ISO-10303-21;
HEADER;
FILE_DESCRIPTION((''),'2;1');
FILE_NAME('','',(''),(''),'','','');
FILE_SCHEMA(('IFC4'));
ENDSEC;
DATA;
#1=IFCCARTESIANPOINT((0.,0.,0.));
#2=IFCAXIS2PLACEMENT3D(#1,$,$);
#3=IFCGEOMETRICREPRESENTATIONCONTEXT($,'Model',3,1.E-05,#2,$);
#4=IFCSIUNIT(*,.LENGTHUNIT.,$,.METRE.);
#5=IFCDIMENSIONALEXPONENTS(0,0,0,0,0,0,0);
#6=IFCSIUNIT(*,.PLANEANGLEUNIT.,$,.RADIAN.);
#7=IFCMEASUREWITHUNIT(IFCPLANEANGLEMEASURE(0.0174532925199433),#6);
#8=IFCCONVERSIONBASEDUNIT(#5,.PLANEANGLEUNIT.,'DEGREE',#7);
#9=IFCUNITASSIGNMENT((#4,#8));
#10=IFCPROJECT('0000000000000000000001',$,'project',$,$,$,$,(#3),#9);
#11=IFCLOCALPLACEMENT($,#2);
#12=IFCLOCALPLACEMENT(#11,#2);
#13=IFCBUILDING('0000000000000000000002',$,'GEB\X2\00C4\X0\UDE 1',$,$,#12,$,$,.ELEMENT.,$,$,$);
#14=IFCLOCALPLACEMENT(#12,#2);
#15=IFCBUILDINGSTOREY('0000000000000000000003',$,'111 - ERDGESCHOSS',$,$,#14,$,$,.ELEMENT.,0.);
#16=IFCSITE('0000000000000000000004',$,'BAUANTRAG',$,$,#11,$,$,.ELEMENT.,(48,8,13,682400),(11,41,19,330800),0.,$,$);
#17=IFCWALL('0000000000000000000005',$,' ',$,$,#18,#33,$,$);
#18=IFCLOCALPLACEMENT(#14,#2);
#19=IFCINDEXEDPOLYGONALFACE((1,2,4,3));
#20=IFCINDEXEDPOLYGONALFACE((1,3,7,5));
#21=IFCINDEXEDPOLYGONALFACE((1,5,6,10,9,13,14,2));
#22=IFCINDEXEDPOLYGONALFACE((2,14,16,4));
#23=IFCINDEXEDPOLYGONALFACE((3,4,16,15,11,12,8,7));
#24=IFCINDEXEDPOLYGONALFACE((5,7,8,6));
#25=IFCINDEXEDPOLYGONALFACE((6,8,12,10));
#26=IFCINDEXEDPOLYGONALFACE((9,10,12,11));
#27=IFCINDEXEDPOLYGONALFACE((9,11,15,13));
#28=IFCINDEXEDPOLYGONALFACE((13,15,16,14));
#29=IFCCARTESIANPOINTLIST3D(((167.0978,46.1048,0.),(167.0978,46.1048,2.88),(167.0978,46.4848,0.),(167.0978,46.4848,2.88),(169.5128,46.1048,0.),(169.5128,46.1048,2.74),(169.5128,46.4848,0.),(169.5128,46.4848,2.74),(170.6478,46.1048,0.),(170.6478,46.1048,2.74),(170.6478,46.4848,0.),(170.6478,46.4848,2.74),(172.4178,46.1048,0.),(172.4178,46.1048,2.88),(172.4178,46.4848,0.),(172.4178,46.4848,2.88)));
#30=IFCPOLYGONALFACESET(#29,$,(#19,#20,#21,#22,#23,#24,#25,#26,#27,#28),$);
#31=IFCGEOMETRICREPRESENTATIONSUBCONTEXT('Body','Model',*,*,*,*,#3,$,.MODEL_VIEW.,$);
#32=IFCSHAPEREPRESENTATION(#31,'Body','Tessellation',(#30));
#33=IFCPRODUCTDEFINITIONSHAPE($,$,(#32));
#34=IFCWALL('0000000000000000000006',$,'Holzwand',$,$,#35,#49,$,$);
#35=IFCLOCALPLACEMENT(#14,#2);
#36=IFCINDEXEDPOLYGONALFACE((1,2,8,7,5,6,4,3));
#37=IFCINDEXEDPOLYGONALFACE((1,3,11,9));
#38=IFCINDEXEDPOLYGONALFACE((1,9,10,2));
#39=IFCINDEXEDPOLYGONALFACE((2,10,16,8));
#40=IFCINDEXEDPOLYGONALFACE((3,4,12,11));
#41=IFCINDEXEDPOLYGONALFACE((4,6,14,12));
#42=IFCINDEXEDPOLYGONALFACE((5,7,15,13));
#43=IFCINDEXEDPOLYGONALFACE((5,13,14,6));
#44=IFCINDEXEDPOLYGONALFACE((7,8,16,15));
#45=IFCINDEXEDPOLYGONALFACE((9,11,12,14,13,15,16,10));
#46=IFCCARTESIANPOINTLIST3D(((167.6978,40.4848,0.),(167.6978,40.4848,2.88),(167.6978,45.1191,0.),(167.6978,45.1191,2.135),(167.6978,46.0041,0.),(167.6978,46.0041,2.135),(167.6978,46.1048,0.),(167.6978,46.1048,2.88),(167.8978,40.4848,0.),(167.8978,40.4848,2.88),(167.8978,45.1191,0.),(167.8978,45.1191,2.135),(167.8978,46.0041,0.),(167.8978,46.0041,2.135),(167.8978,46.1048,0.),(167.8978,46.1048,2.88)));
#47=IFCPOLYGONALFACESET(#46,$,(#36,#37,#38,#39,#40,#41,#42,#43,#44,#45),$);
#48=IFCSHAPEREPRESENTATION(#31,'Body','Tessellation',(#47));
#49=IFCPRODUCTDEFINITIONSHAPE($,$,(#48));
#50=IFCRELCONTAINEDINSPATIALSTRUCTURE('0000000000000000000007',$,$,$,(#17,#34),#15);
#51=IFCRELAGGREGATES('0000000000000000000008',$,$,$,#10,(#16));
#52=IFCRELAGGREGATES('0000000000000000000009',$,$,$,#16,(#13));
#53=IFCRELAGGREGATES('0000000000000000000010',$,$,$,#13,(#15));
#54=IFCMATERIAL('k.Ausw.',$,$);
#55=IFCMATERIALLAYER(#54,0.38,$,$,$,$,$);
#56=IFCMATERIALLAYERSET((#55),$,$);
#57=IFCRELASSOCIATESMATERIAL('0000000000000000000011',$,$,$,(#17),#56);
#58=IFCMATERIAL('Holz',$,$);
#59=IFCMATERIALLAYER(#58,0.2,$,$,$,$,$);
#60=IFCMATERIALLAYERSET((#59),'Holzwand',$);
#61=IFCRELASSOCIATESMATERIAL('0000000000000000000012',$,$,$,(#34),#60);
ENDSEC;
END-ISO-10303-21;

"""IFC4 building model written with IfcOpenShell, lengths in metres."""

from ifc_helpers import new_model, entity, si_unit, converted_unit, frame, frame_2d, origin, origin_with_axes, place, context, subcontext, project, spatial, polyline, rectangle, outline, extrude, material, layer, layer_set, layer_usage, element, save


model = new_model("IFC4")

# Units and contexts
model_context = context("Model", 3, precision=1e-05, world=origin())
body_context = subcontext(model_context, "Body", "Model", "MODEL_VIEW")
ifc_project = project(units=[si_unit("LENGTHUNIT", "METRE"), converted_unit("PLANEANGLEUNIT", "DEGREE", entity("IfcPlaneAngleMeasure", 0.0174532925199433), si_unit("PLANEANGLEUNIT", "RADIAN"), dimensions=[0, 0, 0, 0, 0, 0, 0])], contexts=[model_context])

# Site, building, storey
site_placement = place(None, origin())
site = spatial("IfcSite", under=ifc_project, at=site_placement, Name="BAUANTRAG", CompositionType="ELEMENT", RefLatitude=(48, 8, 13, 682400), RefLongitude=(11, 41, 19, 330800), RefElevation=0.0)
building_placement = place(site_placement, origin())
building = spatial("IfcBuilding", under=site, at=building_placement, Name="GEBÄUDE 1", CompositionType="ELEMENT")
storey_placement = place(building_placement, origin())
storey = spatial("IfcBuildingStorey", under=building, at=storey_placement, Name="111 - ERDGESCHOSS", CompositionType="ELEMENT", Elevation=0.0)

# Walls, openings
ifc_material_1 = material(Name="k.Ausw.")
ifc_layer_1 = layer(ifc_material_1, 0.38)
ifc_layer_set_1 = layer_set([ifc_layer_1])
ifc_layer_usage_1 = layer_usage(ifc_layer_set_1, "AXIS2", "POSITIVE", 0.0)
wall_1_placement = place(storey_placement, frame((172.4178, 46.4848, 0.0), z_axis=(0.0, 0.0, 1.0), x_axis=(-1.0, 0.0, 0.0)))
wall_1 = element("IfcWall", 1, at=wall_1_placement, inside=storey, material=ifc_layer_usage_1, Name=" ", context=body_context, shape_type="SweptSolid", body=[
    extrude(rectangle(XDim=5.32, YDim=0.38, at=frame_2d((2.66, 0.19), x_axis=(1.0, 0.0))), origin_with_axes(), (0.0, 0.0, 1.0), 2.88),
])
opening_1_placement = place(wall_1_placement, frame((2.905, 0.38, 0.0), z_axis=(0.0, -1.0, 0.0), x_axis=(0.0, 0.0, 1.0)))
element("IfcOpeningElement", 2, at=opening_1_placement, cuts=wall_1, ObjectType="Opening", context=body_context, shape_type="SweptSolid", body=[
    extrude(outline(polyline([(0.0, 1.135), (2.74, 1.135), (2.74, 0.0), (0.0, 0.0), (0.0, 1.135)])), origin_with_axes(), (0.0, 0.0, 1.0), 0.38),
])
ifc_material_2 = material(Name="Holz")
ifc_layer_2 = layer(ifc_material_2, 0.2)
ifc_layer_set_2 = layer_set([ifc_layer_2], Name="Holzwand")
ifc_layer_usage_2 = layer_usage(ifc_layer_set_2, "AXIS2", "POSITIVE", 0.0)
wall_2_placement = place(storey_placement, frame((167.6978, 46.1048, 0.0), z_axis=(0.0, 0.0, 1.0), x_axis=(0.0, -1.0, 0.0)))
wall_2 = element("IfcWall", 3, at=wall_2_placement, inside=storey, material=ifc_layer_usage_2, Name="Holzwand", context=body_context, shape_type="SweptSolid", body=[
    extrude(rectangle(XDim=5.62, YDim=0.2, at=frame_2d((2.81, 0.1), x_axis=(1.0, 0.0))), origin_with_axes(), (0.0, 0.0, 1.0), 2.88),
])
opening_2_placement = place(wall_2_placement, frame((0.9857, 0.2, 0.0), z_axis=(0.0, -1.0, 0.0), x_axis=(0.0, 0.0, 1.0)))
element("IfcOpeningElement", 4, at=opening_2_placement, cuts=wall_2, ObjectType="Opening", context=body_context, shape_type="SweptSolid", body=[
    extrude(outline(polyline([(0.0, 0.885), (2.135, 0.885), (2.135, 0.0), (0.0, 0.0), (0.0, 0.885)])), origin_with_axes(), (0.0, 0.0, 1.0), 0.2),
])

save(model, "model.ifc")
